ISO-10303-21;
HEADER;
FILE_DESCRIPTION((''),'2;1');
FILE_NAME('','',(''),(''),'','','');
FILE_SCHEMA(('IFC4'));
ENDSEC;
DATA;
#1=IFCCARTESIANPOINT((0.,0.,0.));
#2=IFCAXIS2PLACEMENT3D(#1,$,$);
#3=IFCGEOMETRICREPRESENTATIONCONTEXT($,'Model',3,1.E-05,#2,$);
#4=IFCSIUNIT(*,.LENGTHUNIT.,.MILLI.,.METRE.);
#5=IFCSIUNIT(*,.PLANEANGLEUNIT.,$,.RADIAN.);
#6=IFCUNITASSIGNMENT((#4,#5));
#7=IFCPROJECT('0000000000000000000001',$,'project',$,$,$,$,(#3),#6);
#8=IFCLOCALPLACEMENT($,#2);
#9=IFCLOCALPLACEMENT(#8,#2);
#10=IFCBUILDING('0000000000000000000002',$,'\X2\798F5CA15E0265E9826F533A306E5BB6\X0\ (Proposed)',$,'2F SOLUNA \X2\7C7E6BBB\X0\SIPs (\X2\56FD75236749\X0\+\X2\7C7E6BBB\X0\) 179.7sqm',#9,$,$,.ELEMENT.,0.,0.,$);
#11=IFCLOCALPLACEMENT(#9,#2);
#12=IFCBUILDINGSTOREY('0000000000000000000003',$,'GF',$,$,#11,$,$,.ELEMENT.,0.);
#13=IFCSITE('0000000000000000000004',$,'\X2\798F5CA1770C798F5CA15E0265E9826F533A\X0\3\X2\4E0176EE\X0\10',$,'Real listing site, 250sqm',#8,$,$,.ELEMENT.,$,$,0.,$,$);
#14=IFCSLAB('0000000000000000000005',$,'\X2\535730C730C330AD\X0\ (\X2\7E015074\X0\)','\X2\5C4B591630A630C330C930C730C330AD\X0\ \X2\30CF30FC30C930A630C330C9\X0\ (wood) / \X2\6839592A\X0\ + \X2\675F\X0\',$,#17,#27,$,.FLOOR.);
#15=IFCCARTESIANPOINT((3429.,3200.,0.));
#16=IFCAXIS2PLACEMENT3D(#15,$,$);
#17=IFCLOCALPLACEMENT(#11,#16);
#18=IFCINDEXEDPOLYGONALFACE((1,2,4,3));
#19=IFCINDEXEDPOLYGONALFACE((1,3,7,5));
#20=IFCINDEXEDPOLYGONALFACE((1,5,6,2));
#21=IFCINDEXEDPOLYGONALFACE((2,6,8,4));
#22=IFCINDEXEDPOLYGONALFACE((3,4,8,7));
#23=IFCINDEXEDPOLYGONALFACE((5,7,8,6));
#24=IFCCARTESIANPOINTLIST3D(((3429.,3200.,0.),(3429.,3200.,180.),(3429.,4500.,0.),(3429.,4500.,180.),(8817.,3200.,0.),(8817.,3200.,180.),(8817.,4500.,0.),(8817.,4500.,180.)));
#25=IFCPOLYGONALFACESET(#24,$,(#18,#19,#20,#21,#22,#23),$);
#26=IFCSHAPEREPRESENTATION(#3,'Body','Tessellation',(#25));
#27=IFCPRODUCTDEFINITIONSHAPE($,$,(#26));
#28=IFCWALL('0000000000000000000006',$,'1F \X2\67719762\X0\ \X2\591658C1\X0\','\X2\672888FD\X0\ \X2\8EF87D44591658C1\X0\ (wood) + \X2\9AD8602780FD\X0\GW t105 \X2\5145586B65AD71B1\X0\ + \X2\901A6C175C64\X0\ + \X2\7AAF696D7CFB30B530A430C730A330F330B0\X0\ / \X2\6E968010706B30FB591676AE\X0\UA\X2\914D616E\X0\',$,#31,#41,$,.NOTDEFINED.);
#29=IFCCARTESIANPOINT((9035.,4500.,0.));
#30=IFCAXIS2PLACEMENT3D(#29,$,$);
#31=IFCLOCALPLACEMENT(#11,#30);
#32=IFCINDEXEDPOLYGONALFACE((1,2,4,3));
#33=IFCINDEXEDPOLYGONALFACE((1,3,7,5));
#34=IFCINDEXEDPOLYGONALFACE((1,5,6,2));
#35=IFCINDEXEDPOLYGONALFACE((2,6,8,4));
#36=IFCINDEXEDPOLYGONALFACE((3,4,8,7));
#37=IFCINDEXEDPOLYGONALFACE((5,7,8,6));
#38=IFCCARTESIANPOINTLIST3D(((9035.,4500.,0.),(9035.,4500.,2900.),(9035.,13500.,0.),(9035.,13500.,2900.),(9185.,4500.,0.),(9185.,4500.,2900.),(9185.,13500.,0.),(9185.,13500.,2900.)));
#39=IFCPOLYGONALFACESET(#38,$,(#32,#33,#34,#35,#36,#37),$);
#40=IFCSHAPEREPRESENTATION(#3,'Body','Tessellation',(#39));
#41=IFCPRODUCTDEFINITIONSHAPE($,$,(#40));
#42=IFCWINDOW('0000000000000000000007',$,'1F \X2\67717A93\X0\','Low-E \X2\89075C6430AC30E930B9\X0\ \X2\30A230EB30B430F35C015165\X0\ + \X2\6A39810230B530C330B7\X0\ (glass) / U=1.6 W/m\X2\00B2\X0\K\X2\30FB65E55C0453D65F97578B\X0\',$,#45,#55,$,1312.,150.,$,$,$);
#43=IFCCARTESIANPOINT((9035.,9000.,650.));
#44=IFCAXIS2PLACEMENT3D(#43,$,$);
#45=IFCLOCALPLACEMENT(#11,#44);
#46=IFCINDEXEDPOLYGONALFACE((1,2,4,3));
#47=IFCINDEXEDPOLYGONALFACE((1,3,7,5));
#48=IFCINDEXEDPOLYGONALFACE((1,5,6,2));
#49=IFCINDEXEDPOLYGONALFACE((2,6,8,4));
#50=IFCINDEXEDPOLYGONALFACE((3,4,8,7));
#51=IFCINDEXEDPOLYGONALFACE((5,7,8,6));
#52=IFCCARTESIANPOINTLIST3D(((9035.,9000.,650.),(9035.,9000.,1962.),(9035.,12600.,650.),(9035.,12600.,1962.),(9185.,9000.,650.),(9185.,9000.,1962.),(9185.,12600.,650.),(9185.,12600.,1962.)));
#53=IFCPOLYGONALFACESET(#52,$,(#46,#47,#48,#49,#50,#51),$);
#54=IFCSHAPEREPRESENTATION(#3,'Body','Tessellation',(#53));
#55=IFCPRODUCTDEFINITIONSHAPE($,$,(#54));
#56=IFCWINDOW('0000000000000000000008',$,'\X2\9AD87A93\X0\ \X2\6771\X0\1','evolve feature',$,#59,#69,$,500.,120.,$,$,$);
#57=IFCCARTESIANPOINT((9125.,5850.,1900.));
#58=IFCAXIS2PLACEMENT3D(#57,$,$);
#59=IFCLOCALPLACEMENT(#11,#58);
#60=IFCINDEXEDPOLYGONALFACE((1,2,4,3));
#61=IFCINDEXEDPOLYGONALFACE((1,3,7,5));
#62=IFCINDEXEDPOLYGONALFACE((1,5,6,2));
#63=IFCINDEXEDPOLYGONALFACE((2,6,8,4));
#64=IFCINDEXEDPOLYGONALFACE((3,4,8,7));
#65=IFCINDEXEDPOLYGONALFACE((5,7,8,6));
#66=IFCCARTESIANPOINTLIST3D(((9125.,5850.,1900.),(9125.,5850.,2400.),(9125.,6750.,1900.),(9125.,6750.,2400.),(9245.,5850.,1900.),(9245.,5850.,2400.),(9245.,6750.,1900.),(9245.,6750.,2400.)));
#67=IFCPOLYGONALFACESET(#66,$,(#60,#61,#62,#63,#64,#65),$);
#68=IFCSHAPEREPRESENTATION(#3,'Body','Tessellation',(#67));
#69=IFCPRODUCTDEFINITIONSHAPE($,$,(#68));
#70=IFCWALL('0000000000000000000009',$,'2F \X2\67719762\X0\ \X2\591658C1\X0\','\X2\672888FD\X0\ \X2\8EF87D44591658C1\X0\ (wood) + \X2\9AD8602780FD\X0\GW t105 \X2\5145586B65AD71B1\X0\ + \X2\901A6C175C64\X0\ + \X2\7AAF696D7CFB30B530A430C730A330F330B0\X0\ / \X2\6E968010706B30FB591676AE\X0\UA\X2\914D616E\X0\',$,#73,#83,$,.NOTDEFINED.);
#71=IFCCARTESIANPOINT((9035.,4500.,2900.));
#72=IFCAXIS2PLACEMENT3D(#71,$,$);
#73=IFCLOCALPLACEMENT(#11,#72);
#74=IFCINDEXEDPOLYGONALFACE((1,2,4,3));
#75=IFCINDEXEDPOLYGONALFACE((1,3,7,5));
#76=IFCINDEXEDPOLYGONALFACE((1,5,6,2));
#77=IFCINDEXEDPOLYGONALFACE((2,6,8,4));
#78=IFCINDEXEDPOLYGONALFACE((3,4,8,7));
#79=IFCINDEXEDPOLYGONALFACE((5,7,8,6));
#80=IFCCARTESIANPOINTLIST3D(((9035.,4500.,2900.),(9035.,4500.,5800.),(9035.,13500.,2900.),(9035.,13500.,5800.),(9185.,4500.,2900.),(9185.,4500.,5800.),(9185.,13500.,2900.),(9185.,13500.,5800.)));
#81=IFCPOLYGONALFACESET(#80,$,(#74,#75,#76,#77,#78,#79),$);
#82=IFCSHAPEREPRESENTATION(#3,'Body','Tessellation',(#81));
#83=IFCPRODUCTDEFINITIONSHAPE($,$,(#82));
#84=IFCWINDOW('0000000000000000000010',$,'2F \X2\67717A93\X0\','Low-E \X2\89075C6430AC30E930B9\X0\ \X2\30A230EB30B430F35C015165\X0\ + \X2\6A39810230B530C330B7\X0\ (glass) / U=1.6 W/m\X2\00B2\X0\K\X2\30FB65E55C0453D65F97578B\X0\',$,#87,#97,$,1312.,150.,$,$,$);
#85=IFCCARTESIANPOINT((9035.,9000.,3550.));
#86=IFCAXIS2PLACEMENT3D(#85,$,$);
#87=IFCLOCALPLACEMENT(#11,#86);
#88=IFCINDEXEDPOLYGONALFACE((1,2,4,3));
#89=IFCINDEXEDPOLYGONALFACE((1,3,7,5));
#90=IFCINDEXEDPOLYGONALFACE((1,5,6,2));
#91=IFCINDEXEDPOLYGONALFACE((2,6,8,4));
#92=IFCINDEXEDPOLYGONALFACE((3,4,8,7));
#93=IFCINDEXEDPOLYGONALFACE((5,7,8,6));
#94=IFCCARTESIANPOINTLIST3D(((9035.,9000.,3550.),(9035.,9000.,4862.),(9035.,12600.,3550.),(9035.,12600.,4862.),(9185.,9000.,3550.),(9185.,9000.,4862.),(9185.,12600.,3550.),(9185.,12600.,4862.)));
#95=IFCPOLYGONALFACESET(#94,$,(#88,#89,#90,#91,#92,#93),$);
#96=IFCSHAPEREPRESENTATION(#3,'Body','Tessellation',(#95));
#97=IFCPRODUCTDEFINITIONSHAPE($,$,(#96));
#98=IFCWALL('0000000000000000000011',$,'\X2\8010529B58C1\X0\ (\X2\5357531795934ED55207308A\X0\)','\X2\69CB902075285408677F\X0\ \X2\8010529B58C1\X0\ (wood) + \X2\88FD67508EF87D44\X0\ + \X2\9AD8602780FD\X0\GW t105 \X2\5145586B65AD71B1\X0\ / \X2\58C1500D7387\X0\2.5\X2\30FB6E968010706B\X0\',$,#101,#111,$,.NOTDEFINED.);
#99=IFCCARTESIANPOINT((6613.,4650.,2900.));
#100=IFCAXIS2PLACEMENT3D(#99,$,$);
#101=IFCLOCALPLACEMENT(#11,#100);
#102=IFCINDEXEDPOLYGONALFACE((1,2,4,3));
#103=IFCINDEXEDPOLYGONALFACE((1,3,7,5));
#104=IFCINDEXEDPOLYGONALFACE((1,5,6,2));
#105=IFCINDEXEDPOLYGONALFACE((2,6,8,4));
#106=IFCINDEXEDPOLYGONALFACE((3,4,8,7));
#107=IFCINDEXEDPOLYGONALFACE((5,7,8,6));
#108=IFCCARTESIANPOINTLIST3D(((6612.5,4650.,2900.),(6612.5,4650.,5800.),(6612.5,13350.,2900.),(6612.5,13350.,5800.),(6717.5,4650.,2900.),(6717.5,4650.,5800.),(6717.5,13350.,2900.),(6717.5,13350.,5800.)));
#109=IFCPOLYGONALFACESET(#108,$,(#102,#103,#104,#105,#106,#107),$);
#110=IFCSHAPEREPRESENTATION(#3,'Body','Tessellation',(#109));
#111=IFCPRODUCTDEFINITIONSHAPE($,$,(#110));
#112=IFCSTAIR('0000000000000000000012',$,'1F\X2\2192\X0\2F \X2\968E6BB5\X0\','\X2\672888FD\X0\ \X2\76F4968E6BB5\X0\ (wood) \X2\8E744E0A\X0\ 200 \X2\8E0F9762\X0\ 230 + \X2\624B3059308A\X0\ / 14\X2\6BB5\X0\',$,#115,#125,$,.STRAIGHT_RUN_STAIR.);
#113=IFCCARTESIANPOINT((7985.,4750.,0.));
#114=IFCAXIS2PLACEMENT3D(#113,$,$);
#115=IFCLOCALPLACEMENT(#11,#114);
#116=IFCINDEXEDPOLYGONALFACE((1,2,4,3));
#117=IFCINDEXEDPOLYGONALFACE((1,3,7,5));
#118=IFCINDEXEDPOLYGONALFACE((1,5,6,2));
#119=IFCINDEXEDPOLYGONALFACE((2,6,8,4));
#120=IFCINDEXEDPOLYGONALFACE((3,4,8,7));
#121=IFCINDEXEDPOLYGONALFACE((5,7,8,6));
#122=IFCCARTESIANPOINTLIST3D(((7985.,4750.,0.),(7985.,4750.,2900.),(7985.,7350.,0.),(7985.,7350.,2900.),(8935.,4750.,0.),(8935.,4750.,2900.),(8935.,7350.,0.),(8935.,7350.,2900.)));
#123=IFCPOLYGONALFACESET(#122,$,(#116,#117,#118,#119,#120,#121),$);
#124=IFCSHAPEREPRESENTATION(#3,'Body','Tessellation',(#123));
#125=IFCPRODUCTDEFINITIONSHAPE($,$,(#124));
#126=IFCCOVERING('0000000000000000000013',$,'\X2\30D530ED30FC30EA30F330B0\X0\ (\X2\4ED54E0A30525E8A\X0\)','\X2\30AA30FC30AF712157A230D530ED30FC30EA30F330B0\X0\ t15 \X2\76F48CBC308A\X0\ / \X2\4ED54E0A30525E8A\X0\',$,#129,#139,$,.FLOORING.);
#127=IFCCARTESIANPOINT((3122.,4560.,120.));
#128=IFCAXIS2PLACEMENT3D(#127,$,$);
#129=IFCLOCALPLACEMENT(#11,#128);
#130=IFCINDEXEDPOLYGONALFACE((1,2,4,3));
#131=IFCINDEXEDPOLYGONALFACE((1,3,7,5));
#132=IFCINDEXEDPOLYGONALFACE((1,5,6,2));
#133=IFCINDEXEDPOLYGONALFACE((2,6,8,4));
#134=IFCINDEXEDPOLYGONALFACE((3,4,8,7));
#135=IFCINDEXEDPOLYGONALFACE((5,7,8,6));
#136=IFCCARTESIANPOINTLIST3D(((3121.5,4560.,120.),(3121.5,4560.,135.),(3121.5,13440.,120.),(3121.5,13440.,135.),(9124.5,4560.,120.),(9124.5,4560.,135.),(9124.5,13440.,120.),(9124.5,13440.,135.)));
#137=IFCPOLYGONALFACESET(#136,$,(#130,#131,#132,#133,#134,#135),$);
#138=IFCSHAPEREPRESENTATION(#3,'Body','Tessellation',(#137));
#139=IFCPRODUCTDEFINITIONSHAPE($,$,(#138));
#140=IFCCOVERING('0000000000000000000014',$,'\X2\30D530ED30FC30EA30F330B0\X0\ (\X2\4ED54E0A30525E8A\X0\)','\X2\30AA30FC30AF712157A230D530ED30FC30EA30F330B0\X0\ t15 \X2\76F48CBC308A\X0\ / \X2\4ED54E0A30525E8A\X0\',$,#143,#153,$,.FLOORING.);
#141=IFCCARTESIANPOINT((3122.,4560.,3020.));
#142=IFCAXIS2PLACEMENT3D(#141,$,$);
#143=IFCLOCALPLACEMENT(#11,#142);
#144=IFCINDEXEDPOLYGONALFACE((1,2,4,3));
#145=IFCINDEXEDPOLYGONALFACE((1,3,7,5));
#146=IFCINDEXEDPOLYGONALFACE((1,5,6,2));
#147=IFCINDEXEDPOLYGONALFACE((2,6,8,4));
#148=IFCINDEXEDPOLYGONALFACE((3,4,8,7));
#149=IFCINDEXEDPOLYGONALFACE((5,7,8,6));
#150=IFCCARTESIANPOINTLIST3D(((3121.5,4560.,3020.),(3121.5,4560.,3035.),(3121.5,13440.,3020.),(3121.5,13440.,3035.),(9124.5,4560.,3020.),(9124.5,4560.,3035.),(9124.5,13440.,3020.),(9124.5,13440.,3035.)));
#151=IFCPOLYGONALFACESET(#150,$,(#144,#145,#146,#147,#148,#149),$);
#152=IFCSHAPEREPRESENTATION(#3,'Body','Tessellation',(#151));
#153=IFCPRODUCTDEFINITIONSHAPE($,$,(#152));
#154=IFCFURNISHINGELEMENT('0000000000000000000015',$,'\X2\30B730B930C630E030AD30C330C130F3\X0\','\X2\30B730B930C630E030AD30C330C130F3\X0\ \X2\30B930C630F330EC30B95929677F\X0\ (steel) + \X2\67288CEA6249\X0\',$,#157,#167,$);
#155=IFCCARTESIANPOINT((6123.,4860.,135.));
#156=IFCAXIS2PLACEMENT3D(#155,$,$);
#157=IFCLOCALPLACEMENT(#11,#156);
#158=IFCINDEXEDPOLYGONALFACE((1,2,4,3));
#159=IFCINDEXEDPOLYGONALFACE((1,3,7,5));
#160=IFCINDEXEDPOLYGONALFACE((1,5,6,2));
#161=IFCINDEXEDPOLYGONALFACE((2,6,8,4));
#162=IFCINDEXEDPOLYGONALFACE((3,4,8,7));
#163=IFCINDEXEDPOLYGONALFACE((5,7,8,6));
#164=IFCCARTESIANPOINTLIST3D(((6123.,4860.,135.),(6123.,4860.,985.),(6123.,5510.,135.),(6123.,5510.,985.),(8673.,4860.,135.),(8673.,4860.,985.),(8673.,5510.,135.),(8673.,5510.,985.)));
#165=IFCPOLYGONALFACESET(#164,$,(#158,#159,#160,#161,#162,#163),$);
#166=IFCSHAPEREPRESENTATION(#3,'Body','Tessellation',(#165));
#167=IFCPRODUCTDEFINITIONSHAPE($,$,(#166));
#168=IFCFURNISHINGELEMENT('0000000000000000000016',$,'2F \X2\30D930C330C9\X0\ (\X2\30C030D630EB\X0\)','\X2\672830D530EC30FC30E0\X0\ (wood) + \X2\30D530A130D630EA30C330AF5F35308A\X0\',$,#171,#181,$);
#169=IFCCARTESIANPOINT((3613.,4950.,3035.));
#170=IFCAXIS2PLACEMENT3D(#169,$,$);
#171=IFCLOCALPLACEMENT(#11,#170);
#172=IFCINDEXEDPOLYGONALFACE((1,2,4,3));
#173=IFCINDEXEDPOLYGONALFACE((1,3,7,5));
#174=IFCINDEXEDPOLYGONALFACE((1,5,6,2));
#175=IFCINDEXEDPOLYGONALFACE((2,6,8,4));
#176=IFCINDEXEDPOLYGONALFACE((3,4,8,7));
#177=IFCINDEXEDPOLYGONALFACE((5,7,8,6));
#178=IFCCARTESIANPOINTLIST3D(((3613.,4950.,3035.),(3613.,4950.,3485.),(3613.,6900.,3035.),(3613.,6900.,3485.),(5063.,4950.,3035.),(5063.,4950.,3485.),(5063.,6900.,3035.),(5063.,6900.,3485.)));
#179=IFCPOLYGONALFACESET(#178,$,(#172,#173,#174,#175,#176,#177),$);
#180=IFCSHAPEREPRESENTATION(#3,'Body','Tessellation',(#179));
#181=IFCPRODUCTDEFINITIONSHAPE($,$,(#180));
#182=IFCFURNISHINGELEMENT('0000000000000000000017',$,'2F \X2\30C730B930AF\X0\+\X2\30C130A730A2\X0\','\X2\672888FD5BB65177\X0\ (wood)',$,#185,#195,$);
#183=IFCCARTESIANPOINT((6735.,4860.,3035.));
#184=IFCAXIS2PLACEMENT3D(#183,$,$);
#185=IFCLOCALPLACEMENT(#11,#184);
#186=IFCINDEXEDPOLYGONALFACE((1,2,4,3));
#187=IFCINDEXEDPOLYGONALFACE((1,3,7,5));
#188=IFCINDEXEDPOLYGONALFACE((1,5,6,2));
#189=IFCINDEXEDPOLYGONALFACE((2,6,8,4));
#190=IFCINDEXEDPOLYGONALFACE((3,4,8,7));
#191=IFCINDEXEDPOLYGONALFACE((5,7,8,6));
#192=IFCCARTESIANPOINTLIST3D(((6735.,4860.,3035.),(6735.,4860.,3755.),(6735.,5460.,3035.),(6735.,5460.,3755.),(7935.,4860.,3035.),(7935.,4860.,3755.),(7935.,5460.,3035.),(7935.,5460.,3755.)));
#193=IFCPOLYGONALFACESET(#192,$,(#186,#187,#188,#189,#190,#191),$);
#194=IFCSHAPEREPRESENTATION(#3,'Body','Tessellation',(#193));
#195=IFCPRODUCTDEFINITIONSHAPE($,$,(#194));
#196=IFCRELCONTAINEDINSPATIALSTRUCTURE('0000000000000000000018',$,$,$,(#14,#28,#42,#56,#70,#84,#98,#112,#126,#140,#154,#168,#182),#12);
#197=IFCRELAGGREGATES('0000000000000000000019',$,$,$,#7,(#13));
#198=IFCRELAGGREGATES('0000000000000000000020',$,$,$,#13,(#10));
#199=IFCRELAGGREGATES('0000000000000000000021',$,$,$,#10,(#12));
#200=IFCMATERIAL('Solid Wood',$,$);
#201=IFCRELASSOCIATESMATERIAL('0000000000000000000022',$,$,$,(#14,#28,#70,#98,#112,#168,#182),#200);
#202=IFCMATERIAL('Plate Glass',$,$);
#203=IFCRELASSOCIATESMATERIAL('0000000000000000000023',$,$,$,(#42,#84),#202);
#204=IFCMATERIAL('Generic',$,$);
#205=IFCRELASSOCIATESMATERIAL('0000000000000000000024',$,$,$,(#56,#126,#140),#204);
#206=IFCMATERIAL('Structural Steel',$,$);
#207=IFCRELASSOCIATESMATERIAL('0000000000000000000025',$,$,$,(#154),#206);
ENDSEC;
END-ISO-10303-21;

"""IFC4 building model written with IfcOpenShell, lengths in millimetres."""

from ifc_helpers import new_model, si_unit, frame, frame_2d, origin, place, context, project, spatial, rectangle, extrude, material, element, fill, save


model = new_model("IFC4")

# Units and contexts
model_context = context("Model", 3, precision=1e-05, world=origin())
ifc_project = project(units=[si_unit("LENGTHUNIT", "METRE", prefix="MILLI"), si_unit("PLANEANGLEUNIT", "RADIAN")], contexts=[model_context])

# Site, building, storey
site_placement = place(None, origin())
site = spatial("IfcSite", under=ifc_project, at=site_placement, Name="福岡県福岡市早良区3丁目10", ObjectType="Real listing site, 250sqm", CompositionType="ELEMENT", RefElevation=0.0)
building_placement = place(site_placement, origin())
building = spatial("IfcBuilding", under=site, at=building_placement, Name="福岡市早良区の家 (Proposed)", ObjectType="2F SOLUNA 籾殻SIPs (国産杉+籾殻) 179.7sqm", CompositionType="ELEMENT", ElevationOfRefHeight=0.0, ElevationOfTerrain=0.0)
storey_placement = place(building_placement, origin())
storey = spatial("IfcBuildingStorey", under=building, at=storey_placement, Name="GF", CompositionType="ELEMENT", Elevation=0.0)

# Slab
ifc_material_1 = material(Name="Solid Wood")
slab_placement = place(storey_placement, frame((3429.0, 3200.0, 0.0)))
element("IfcSlab", 1, at=slab_placement, inside=storey, material=ifc_material_1, Name="南デッキ (縁側)", Description="屋外ウッドデッキ ハードウッド (wood) / 根太 + 束", PredefinedType="FLOOR", context=model_context, shape_type="SweptSolid", body=[
    extrude(rectangle(XDim=5388.0, YDim=1300.0, at=frame_2d((2694.0, 650.0))), frame((3429.0, 3200.0, 0.0)), (0.0, 0.0, 1.0), 180.0),
])

# Wall, openings, windows
wall_1_placement = place(storey_placement, frame((9035.0, 4500.0, 0.0)))
wall_1 = element("IfcWall", 2, at=wall_1_placement, inside=storey, material=ifc_material_1, Name="1F 東面 外壁", Description="木製 軸組外壁 (wood) + 高性能GW t105 充填断熱 + 通気層 + 窯業系サイディング / 準耐火・外皮UA配慮", PredefinedType="NOTDEFINED", context=model_context, shape_type="SweptSolid", body=[
    extrude(rectangle(XDim=150.0, YDim=9000.0, at=frame_2d((75.0, 4500.0))), frame((9035.0, 4500.0, 0.0)), (0.0, 0.0, 1.0), 2900.0),
])
opening_1_placement = place(storey_placement, frame((9035.0, 9000.0, 650.0)))
opening_1 = element("IfcOpeningElement", 3, at=opening_1_placement, cuts=wall_1, PredefinedType="NOTDEFINED", context=model_context, shape_type="SweptSolid", body=[
    extrude(rectangle(XDim=150.0, YDim=3600.0, at=frame_2d((75.0, 1800.0))), frame((9035.0, 9000.0, 650.0)), (0.0, 0.0, 1.0), 1312.0),
])
opening_2_placement = place(storey_placement, frame((9125.0, 5850.0, 1900.0)))
opening_2 = element("IfcOpeningElement", 4, at=opening_2_placement, cuts=wall_1, PredefinedType="NOTDEFINED", context=model_context, shape_type="SweptSolid", body=[
    extrude(rectangle(XDim=120.0, YDim=900.0, at=frame_2d((60.0, 450.0))), frame((9125.0, 5850.0, 1900.0)), (0.0, 0.0, 1.0), 500.0),
])
ifc_material_2 = material(Name="Plate Glass")
window_1_placement = place(storey_placement, frame((9035.0, 9000.0, 650.0)))
window_1 = element("IfcWindow", 5, at=window_1_placement, inside=storey, material=ifc_material_2, Name="1F 東窓", Description="Low-E 複層ガラス アルゴン封入 + 樹脂サッシ (glass) / U=1.6 W/m²K・日射取得型", OverallHeight=1312.0, OverallWidth=150.0, context=model_context, shape_type="SweptSolid", body=[
    extrude(rectangle(XDim=150.0, YDim=3600.0, at=frame_2d((75.0, 1800.0))), frame((9035.0, 9000.0, 650.0)), (0.0, 0.0, 1.0), 1312.0),
])
fill(opening_1, window_1)
ifc_material_3 = material(Name="Generic")
window_2_placement = place(storey_placement, frame((9125.0, 5850.0, 1900.0)))
window_2 = element("IfcWindow", 6, at=window_2_placement, inside=storey, material=ifc_material_3, Name="高窓 東1", Description="evolve feature", OverallHeight=500.0, OverallWidth=120.0, context=model_context, shape_type="SweptSolid", body=[
    extrude(rectangle(XDim=120.0, YDim=900.0, at=frame_2d((60.0, 450.0))), frame((9125.0, 5850.0, 1900.0)), (0.0, 0.0, 1.0), 500.0),
])
fill(opening_2, window_2)

# Wall, opening, window
wall_2_placement = place(storey_placement, frame((9035.0, 4500.0, 2900.0)))
wall_2 = element("IfcWall", 7, at=wall_2_placement, inside=storey, material=ifc_material_1, Name="2F 東面 外壁", Description="木製 軸組外壁 (wood) + 高性能GW t105 充填断熱 + 通気層 + 窯業系サイディング / 準耐火・外皮UA配慮", PredefinedType="NOTDEFINED", context=model_context, shape_type="SweptSolid", body=[
    extrude(rectangle(XDim=150.0, YDim=9000.0, at=frame_2d((75.0, 4500.0))), frame((9035.0, 4500.0, 2900.0)), (0.0, 0.0, 1.0), 2900.0),
])
opening_3_placement = place(storey_placement, frame((9035.0, 9000.0, 3550.0)))
opening_3 = element("IfcOpeningElement", 8, at=opening_3_placement, cuts=wall_2, PredefinedType="NOTDEFINED", context=model_context, shape_type="SweptSolid", body=[
    extrude(rectangle(XDim=150.0, YDim=3600.0, at=frame_2d((75.0, 1800.0))), frame((9035.0, 9000.0, 3550.0)), (0.0, 0.0, 1.0), 1312.0),
])
window_3_placement = place(storey_placement, frame((9035.0, 9000.0, 3550.0)))
window_3 = element("IfcWindow", 9, at=window_3_placement, inside=storey, material=ifc_material_2, Name="2F 東窓", Description="Low-E 複層ガラス アルゴン封入 + 樹脂サッシ (glass) / U=1.6 W/m²K・日射取得型", OverallHeight=1312.0, OverallWidth=150.0, context=model_context, shape_type="SweptSolid", body=[
    extrude(rectangle(XDim=150.0, YDim=3600.0, at=frame_2d((75.0, 1800.0))), frame((9035.0, 9000.0, 3550.0)), (0.0, 0.0, 1.0), 1312.0),
])
fill(opening_3, window_3)

# Wall
wall_3_placement = place(storey_placement, frame((6613.0, 4650.0, 2900.0)))
element("IfcWall", 10, at=wall_3_placement, inside=storey, material=ifc_material_1, Name="耐力壁 (南北間仕切り)", Description="構造用合板 耐力壁 (wood) + 製材軸組 + 高性能GW t105 充填断熱 / 壁倍率2.5・準耐火", PredefinedType="NOTDEFINED", context=model_context, shape_type="SweptSolid", body=[
    extrude(rectangle(XDim=105.0, YDim=8700.0, at=frame_2d((52.0, 4350.0))), frame((6613.0, 4650.0, 2900.0)), (0.0, 0.0, 1.0), 2900.0),
])

# Stair
stair_placement = place(storey_placement, frame((7985.0, 4750.0, 0.0)))
element("IfcStair", 11, at=stair_placement, inside=storey, material=ifc_material_1, Name="1F→2F 階段", Description="木製 直階段 (wood) 蹴上 200 踏面 230 + 手すり / 14段", PredefinedType="STRAIGHT_RUN_STAIR", context=model_context, shape_type="SweptSolid", body=[
    extrude(rectangle(XDim=950.0, YDim=2600.0, at=frame_2d((475.0, 1300.0))), frame((7985.0, 4750.0, 0.0)), (0.0, 0.0, 1.0), 2900.0),
])

# Coverings
covering_1_placement = place(storey_placement, frame((3122.0, 4560.0, 120.0)))
element("IfcCovering", 12, at=covering_1_placement, inside=storey, material=ifc_material_3, Name="フローリング (仕上げ床)", Description="オーク無垢フローリング t15 直貼り / 仕上げ床", PredefinedType="FLOORING", context=model_context, shape_type="SweptSolid", body=[
    extrude(rectangle(XDim=6003.0, YDim=8880.0, at=frame_2d((3001.0, 4440.0))), frame((3122.0, 4560.0, 120.0)), (0.0, 0.0, 1.0), 15.0),
])
covering_2_placement = place(storey_placement, frame((3122.0, 4560.0, 3020.0)))
element("IfcCovering", 13, at=covering_2_placement, inside=storey, material=ifc_material_3, Name="フローリング (仕上げ床)", Description="オーク無垢フローリング t15 直貼り / 仕上げ床", PredefinedType="FLOORING", context=model_context, shape_type="SweptSolid", body=[
    extrude(rectangle(XDim=6003.0, YDim=8880.0, at=frame_2d((3001.0, 4440.0))), frame((3122.0, 4560.0, 3020.0)), (0.0, 0.0, 1.0), 15.0),
])

# Furnishing elements
ifc_material_4 = material(Name="Structural Steel")
furnishing_1_placement = place(storey_placement, frame((6123.0, 4860.0, 135.0)))
element("IfcFurnishingElement", 14, at=furnishing_1_placement, inside=storey, material=ifc_material_4, Name="システムキッチン", Description="システムキッチン ステンレス天板 (steel) + 木質扉", context=model_context, shape_type="SweptSolid", body=[
    extrude(rectangle(XDim=2550.0, YDim=650.0, at=frame_2d((1275.0, 325.0))), frame((6123.0, 4860.0, 135.0)), (0.0, 0.0, 1.0), 850.0),
])
furnishing_2_placement = place(storey_placement, frame((3613.0, 4950.0, 3035.0)))
element("IfcFurnishingElement", 15, at=furnishing_2_placement, inside=storey, material=ifc_material_1, Name="2F ベッド (ダブル)", Description="木フレーム (wood) + ファブリック張り", context=model_context, shape_type="SweptSolid", body=[
    extrude(rectangle(XDim=1450.0, YDim=1950.0, at=frame_2d((725.0, 975.0))), frame((3613.0, 4950.0, 3035.0)), (0.0, 0.0, 1.0), 450.0),
])
furnishing_3_placement = place(storey_placement, frame((6735.0, 4860.0, 3035.0)))
element("IfcFurnishingElement", 16, at=furnishing_3_placement, inside=storey, material=ifc_material_1, Name="2F デスク+チェア", Description="木製家具 (wood)", context=model_context, shape_type="SweptSolid", body=[
    extrude(rectangle(XDim=1200.0, YDim=600.0, at=frame_2d((600.0, 300.0))), frame((6735.0, 4860.0, 3035.0)), (0.0, 0.0, 1.0), 720.0),
])

save(model, "model.ifc")
